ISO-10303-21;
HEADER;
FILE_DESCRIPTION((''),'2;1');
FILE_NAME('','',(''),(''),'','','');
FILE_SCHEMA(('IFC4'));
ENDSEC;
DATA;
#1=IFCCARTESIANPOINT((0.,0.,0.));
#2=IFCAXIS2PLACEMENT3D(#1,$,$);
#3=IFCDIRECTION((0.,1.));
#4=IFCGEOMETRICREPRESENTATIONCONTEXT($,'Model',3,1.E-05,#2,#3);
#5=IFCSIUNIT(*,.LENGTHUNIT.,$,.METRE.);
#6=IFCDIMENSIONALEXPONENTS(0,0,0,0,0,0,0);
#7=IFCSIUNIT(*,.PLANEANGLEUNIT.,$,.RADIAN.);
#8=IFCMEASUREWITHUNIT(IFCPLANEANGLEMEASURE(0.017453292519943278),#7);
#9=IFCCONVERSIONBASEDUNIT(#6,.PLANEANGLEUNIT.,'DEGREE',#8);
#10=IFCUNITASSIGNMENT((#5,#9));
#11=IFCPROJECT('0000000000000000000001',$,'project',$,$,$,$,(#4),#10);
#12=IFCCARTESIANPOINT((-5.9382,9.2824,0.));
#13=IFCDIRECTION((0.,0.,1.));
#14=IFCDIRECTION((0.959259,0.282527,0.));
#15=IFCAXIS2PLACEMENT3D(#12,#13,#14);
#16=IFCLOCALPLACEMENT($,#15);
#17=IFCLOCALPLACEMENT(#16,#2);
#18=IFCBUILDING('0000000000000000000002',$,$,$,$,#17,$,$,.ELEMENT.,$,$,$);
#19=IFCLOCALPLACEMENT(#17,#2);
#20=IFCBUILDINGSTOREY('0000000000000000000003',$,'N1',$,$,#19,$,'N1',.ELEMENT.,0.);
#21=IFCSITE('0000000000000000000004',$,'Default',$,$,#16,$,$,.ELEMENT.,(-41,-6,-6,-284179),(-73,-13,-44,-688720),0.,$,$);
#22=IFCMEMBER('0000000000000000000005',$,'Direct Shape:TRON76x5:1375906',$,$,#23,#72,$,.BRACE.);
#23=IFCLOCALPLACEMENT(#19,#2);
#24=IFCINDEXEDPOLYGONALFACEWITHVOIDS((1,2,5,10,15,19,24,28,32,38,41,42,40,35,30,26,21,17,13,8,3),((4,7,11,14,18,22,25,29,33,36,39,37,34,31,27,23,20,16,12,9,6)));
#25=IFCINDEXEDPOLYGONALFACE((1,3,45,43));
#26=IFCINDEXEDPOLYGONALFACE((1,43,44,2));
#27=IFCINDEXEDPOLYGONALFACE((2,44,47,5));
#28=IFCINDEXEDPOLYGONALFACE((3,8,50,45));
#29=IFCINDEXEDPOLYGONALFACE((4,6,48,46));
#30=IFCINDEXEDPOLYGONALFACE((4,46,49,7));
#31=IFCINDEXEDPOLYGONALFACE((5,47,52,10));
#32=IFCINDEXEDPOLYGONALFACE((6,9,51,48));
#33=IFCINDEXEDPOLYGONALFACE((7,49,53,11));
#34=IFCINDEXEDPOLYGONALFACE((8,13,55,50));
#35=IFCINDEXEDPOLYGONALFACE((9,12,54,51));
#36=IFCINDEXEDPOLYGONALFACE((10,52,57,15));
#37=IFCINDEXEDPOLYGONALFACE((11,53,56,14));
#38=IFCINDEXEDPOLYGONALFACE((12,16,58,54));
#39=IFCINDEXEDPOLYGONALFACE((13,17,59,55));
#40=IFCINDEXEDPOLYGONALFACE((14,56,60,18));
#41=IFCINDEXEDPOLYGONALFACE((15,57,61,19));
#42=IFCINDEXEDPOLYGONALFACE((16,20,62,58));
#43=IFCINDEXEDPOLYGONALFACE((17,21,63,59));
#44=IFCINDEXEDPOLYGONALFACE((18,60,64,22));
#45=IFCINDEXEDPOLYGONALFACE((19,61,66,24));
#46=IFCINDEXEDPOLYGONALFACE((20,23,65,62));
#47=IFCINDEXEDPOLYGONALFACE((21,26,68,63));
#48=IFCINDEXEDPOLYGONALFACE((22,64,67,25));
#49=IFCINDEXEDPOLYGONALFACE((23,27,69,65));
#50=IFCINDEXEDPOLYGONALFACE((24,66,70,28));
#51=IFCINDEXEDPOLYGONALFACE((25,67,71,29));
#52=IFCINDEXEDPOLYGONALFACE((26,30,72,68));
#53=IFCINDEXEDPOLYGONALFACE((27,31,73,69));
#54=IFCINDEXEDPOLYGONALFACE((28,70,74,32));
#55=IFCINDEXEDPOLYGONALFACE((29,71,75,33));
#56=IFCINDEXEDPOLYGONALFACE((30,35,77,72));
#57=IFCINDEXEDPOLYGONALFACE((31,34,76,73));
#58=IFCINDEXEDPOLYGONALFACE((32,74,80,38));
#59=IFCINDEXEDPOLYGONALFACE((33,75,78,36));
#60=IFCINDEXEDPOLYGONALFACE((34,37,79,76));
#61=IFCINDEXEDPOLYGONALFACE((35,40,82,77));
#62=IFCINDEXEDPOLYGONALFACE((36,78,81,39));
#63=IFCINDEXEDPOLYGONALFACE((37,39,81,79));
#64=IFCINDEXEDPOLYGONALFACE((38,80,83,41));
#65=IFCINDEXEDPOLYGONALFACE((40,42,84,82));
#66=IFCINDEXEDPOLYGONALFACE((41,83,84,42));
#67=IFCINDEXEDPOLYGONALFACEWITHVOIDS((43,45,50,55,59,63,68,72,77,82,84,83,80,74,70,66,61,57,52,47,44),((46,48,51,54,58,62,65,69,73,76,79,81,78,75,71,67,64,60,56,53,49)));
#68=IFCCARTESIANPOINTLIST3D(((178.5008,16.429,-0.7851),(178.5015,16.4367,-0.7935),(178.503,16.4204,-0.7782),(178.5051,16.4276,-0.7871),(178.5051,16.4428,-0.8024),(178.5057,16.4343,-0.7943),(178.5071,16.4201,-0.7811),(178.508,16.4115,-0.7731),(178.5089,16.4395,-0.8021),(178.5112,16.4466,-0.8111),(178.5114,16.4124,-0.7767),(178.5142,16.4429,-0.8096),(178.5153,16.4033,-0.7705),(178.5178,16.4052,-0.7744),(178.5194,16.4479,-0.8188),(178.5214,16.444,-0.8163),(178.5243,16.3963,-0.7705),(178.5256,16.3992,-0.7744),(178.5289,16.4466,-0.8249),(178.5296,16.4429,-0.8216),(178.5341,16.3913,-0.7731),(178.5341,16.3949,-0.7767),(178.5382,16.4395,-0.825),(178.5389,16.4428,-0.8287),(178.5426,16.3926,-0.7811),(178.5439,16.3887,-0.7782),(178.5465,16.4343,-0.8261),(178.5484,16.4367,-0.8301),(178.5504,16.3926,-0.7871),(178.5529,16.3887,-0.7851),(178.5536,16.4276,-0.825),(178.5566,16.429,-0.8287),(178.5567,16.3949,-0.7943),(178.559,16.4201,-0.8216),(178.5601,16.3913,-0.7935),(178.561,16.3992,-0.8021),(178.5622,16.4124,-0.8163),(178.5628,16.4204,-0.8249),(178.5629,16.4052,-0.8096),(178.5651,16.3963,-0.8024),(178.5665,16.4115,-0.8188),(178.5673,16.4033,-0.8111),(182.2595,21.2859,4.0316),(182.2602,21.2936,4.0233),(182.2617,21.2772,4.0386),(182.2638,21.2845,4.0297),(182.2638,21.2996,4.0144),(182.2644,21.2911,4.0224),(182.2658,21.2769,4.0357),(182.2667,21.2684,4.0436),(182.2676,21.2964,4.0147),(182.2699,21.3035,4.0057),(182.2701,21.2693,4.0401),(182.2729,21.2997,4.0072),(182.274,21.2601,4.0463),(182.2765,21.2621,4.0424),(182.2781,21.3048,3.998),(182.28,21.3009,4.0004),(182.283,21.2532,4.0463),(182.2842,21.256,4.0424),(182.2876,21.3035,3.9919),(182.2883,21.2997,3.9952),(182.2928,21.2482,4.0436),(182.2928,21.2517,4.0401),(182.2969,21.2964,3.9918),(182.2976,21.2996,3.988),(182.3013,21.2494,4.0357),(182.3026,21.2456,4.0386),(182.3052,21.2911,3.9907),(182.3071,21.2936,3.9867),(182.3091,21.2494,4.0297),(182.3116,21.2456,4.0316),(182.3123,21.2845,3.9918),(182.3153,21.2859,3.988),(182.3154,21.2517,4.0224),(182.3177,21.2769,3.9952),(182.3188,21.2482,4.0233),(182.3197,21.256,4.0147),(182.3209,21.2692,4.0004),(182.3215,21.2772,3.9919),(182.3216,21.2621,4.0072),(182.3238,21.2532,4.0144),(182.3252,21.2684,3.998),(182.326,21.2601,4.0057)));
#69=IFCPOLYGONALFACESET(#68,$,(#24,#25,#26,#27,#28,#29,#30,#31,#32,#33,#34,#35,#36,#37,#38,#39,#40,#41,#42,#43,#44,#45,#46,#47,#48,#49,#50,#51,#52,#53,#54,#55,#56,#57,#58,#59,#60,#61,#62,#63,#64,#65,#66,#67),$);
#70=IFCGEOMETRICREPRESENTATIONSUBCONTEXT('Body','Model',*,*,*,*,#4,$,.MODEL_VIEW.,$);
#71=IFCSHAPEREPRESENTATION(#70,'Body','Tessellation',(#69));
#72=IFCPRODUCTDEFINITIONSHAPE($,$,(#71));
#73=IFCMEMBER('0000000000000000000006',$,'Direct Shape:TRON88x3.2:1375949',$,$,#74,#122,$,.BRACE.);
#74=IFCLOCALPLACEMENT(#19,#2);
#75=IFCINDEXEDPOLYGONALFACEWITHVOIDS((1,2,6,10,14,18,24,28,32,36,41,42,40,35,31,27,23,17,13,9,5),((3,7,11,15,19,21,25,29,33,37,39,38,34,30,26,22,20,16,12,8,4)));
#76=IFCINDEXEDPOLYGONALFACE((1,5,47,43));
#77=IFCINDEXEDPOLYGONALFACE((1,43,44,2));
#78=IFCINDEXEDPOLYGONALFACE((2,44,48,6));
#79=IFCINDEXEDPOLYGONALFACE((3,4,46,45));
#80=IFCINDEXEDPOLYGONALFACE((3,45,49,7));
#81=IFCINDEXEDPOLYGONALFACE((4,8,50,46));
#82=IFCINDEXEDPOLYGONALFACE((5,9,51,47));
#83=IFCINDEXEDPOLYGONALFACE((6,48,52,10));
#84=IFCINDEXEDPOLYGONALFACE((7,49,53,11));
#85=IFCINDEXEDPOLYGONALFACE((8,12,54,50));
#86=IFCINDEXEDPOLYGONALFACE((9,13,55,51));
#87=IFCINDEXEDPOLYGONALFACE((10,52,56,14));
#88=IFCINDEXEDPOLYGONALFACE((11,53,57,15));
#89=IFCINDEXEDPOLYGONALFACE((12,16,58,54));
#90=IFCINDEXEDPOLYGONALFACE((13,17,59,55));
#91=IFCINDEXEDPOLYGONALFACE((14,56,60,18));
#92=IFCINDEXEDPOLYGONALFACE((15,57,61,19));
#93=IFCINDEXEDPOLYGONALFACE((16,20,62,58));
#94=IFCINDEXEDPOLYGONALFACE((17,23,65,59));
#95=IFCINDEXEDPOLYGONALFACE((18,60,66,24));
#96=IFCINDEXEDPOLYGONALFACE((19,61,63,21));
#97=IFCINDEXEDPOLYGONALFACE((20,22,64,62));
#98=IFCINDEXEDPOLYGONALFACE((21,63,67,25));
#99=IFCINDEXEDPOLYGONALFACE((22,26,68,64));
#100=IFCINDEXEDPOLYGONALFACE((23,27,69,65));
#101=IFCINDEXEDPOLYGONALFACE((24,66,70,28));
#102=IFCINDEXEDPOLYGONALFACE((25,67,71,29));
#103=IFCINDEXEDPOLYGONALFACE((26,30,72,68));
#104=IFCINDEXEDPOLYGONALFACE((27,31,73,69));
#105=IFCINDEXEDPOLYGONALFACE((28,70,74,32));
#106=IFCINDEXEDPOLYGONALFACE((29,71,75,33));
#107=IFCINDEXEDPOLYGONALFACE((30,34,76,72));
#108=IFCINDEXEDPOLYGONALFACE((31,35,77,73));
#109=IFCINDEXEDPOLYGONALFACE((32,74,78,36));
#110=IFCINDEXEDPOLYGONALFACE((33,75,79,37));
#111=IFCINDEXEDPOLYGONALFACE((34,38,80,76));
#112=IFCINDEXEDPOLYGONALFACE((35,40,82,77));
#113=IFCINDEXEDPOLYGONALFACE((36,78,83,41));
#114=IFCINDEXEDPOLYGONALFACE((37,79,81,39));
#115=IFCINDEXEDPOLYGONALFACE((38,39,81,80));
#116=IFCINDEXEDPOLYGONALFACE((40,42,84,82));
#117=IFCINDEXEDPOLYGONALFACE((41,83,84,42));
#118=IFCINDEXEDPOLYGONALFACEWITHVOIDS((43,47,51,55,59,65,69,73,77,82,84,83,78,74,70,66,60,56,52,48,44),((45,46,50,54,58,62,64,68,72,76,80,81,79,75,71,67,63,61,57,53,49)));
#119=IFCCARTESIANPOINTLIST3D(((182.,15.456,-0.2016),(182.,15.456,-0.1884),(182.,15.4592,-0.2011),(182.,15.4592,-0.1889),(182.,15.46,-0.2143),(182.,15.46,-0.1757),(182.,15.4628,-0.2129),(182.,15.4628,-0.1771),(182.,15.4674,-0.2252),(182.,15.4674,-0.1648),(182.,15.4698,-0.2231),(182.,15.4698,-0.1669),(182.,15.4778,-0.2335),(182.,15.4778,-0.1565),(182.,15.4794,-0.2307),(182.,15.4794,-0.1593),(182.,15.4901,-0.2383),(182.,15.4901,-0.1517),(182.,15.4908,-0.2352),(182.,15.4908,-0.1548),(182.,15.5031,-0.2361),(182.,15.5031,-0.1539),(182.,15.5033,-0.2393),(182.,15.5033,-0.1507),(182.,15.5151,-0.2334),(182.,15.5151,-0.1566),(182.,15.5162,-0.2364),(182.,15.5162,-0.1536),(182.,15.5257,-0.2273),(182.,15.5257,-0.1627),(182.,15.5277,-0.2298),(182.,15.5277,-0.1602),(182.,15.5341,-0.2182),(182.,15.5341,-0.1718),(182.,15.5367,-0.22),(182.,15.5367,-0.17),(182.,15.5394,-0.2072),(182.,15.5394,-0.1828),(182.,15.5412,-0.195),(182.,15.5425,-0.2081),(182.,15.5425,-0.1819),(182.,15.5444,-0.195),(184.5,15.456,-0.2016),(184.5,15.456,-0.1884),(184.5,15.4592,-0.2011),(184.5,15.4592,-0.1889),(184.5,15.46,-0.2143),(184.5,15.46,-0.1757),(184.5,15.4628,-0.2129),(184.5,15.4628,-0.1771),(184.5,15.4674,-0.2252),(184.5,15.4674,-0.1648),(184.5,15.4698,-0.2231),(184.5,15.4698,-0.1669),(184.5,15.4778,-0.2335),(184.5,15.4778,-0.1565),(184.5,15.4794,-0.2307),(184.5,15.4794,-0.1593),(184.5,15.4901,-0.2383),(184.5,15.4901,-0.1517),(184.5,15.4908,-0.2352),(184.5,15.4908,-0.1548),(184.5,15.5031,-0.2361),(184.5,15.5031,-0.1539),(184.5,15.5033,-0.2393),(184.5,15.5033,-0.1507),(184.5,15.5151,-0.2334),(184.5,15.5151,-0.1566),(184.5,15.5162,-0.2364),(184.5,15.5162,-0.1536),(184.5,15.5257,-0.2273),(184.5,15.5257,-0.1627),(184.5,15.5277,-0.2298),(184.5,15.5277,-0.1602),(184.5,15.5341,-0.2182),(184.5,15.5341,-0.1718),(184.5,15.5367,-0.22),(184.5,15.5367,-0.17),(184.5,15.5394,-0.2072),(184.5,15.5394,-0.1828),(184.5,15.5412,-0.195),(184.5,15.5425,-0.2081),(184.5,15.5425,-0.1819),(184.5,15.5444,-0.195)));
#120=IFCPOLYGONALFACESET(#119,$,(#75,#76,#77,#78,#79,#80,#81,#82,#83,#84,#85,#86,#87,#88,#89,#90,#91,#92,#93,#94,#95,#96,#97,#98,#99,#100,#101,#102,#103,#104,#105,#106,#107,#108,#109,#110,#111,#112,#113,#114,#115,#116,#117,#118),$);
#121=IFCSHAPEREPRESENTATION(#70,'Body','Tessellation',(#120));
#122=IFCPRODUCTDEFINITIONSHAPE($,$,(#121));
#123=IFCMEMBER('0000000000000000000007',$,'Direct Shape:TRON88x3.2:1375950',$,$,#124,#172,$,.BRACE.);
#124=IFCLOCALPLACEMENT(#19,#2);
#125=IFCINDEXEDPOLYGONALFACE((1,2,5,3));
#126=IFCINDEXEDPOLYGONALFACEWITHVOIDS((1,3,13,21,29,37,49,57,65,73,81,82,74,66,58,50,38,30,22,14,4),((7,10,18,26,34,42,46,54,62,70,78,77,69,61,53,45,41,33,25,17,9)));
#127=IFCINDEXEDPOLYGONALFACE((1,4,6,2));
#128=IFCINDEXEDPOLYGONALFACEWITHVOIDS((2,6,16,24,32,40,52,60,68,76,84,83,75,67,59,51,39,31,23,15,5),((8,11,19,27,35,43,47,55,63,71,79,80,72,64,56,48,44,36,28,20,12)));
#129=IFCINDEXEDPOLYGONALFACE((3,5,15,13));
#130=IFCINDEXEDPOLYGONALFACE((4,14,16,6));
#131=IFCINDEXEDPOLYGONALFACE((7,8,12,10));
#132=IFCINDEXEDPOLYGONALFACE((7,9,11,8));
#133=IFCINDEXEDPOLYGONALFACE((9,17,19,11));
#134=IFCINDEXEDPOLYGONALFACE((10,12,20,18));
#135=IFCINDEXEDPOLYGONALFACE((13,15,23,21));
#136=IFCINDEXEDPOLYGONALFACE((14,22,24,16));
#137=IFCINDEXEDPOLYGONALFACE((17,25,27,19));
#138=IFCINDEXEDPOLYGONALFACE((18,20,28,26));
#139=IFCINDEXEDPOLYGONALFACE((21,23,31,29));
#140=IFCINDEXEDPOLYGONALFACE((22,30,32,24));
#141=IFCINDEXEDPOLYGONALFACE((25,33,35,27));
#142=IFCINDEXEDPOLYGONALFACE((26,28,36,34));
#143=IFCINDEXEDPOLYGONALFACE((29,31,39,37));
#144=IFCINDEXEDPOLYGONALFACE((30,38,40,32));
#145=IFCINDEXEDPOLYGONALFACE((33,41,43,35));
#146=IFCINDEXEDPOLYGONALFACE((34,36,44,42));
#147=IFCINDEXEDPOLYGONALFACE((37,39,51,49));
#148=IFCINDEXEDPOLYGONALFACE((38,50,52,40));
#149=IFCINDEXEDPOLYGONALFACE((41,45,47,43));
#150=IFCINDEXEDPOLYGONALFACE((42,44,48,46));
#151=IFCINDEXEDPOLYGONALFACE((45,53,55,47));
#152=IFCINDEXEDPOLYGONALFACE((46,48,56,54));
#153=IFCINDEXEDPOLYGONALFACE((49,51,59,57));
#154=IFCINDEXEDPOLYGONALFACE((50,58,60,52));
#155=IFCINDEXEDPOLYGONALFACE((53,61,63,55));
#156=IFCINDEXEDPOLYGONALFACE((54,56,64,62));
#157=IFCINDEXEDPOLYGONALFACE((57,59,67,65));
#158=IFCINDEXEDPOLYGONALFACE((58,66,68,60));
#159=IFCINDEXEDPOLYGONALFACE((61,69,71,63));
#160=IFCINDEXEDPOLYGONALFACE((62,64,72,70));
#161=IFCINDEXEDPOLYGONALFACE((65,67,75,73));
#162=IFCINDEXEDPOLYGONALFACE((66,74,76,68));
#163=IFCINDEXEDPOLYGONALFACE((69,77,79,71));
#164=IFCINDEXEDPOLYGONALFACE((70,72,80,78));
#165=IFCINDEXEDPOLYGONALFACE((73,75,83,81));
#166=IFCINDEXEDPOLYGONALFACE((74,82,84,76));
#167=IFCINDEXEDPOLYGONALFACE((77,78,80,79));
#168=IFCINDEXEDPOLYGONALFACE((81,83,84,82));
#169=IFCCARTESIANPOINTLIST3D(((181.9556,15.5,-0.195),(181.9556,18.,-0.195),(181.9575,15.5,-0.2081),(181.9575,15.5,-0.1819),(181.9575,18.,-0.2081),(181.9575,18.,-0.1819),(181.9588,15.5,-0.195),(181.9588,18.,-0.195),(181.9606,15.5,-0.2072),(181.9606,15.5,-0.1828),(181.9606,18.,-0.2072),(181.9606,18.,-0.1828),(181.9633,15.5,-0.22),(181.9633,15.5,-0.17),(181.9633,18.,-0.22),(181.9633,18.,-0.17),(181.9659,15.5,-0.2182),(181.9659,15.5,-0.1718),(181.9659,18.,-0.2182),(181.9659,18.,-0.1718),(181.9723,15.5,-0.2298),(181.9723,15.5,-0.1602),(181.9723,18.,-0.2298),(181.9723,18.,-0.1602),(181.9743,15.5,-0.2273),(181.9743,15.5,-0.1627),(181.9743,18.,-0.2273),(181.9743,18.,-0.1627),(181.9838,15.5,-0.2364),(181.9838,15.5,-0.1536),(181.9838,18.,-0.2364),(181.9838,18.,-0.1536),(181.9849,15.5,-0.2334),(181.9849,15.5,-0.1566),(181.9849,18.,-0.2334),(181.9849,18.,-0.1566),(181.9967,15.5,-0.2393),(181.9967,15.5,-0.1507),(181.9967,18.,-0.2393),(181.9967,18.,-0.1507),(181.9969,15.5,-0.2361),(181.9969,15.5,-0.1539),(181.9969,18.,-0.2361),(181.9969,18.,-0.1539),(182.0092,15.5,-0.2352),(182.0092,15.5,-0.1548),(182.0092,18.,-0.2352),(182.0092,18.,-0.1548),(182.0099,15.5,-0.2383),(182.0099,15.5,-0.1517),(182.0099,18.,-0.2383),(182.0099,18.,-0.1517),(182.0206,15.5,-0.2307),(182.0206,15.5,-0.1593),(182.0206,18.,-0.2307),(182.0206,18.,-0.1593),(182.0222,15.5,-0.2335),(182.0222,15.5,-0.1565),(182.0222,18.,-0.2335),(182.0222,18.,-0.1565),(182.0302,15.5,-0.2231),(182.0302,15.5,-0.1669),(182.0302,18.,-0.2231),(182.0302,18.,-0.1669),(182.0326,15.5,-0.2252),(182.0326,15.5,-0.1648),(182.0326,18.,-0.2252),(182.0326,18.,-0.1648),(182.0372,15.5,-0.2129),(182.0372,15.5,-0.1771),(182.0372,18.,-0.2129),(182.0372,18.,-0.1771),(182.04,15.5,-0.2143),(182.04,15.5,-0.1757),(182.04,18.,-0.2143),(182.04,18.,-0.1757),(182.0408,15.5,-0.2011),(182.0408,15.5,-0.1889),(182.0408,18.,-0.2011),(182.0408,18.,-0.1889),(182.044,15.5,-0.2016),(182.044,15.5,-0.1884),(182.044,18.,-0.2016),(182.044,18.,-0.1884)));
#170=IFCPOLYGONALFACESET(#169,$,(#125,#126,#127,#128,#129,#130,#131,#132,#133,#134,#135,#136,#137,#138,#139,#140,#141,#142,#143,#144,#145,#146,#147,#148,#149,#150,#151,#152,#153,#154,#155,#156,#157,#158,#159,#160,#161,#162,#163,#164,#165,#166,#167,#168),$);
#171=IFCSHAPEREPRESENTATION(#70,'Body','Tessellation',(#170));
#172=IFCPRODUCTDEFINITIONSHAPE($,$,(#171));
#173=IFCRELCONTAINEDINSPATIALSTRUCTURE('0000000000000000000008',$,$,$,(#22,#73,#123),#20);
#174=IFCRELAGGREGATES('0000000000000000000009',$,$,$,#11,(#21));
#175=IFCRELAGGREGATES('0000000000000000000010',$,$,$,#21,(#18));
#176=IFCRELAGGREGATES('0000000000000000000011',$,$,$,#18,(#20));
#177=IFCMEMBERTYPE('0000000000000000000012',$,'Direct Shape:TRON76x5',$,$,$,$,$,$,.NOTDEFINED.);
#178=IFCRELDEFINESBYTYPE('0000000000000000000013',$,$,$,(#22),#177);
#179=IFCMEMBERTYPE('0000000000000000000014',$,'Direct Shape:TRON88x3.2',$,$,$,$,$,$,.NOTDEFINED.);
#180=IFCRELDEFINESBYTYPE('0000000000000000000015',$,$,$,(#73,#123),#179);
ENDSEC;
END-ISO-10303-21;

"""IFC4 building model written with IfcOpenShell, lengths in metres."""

from ifc_helpers import new_model, entity, si_unit, converted_unit, direction, frame, frame_2d, origin, origin_2d_with_axis, place, context, subcontext, project, spatial, hollow_circle, extrude, type_object, element, save


model = new_model("IFC4")

# Units and contexts
model_context = context("Model", 3, precision=1e-05, world=origin(), true_north=direction((0.0, 1.0)))
body_context = subcontext(model_context, "Body", "Model", "MODEL_VIEW")
ifc_project = project(units=[si_unit("LENGTHUNIT", "METRE"), converted_unit("PLANEANGLEUNIT", "DEGREE", entity("IfcPlaneAngleMeasure", 0.017453292519943278), si_unit("PLANEANGLEUNIT", "RADIAN"), dimensions=[0, 0, 0, 0, 0, 0, 0])], contexts=[model_context])

# Site, building, storey
site_placement = place(None, frame((-5.9382, 9.2824, 0.0), z_axis=(0.0, 0.0, 1.0), x_axis=(0.959259, 0.282527, 0.0)))
site = spatial("IfcSite", under=ifc_project, at=site_placement, Name="Default", CompositionType="ELEMENT", RefLatitude=(-41, -6, -6, -284179), RefLongitude=(-73, -13, -44, -688720), RefElevation=0.0)
building_placement = place(site_placement, origin())
building = spatial("IfcBuilding", under=site, at=building_placement, CompositionType="ELEMENT")
storey_placement = place(building_placement, origin())
storey = spatial("IfcBuildingStorey", under=building, at=storey_placement, Name="N1", LongName="N1", CompositionType="ELEMENT", Elevation=0.0)

# Members
member_type_1 = type_object("IfcMemberType", Name="Direct Shape:TRON76x5", PredefinedType="NOTDEFINED")
member_1_placement = place(storey_placement, origin())
element("IfcMember", 1, at=member_1_placement, inside=storey, type_object=member_type_1, Name="Direct Shape:TRON76x5:1375906", PredefinedType="BRACE", context=body_context, shape_type="SweptSolid", body=[
    extrude(hollow_circle(Radius=0.0381, WallThickness=0.005, at=origin_2d_with_axis()), frame((178.534, 16.4182, -0.8001), z_axis=(0.481575, 0.622274, 0.61714), x_axis=(0.377705, 0.488057, -0.786854)), (0.0, 0.0, 1.0), 7.805),
])
member_type_2 = type_object("IfcMemberType", Name="Direct Shape:TRON88x3.2", PredefinedType="NOTDEFINED")
member_2_placement = place(storey_placement, origin())
element("IfcMember", 2, at=member_2_placement, inside=storey, type_object=member_type_2, Name="Direct Shape:TRON88x3.2:1375949", PredefinedType="BRACE", context=body_context, shape_type="SweptSolid", body=[
    extrude(hollow_circle(Radius=0.0445, WallThickness=0.0032, at=frame_2d((0.0, 0.0), x_axis=(1.0, 0.0))), frame((182.0, 15.5, -0.195), z_axis=(1.0, 0.0, 0.0), x_axis=(0.0, 1.0, 0.0)), (0.0, 0.0, 1.0), 2.5),
])
member_3_placement = place(storey_placement, origin())
element("IfcMember", 3, at=member_3_placement, inside=storey, type_object=member_type_2, Name="Direct Shape:TRON88x3.2:1375950", PredefinedType="BRACE", context=body_context, shape_type="SweptSolid", body=[
    extrude(hollow_circle(Radius=0.0445, WallThickness=0.0032, at=frame_2d((0.0, 0.0), x_axis=(1.0, 0.0))), frame((182.0, 15.5, -0.195), z_axis=(0.0, 1.0, 0.0), x_axis=(-1.0, 0.0, 0.0)), (0.0, 0.0, 1.0), 2.5),
])

save(model, "model.ifc")
